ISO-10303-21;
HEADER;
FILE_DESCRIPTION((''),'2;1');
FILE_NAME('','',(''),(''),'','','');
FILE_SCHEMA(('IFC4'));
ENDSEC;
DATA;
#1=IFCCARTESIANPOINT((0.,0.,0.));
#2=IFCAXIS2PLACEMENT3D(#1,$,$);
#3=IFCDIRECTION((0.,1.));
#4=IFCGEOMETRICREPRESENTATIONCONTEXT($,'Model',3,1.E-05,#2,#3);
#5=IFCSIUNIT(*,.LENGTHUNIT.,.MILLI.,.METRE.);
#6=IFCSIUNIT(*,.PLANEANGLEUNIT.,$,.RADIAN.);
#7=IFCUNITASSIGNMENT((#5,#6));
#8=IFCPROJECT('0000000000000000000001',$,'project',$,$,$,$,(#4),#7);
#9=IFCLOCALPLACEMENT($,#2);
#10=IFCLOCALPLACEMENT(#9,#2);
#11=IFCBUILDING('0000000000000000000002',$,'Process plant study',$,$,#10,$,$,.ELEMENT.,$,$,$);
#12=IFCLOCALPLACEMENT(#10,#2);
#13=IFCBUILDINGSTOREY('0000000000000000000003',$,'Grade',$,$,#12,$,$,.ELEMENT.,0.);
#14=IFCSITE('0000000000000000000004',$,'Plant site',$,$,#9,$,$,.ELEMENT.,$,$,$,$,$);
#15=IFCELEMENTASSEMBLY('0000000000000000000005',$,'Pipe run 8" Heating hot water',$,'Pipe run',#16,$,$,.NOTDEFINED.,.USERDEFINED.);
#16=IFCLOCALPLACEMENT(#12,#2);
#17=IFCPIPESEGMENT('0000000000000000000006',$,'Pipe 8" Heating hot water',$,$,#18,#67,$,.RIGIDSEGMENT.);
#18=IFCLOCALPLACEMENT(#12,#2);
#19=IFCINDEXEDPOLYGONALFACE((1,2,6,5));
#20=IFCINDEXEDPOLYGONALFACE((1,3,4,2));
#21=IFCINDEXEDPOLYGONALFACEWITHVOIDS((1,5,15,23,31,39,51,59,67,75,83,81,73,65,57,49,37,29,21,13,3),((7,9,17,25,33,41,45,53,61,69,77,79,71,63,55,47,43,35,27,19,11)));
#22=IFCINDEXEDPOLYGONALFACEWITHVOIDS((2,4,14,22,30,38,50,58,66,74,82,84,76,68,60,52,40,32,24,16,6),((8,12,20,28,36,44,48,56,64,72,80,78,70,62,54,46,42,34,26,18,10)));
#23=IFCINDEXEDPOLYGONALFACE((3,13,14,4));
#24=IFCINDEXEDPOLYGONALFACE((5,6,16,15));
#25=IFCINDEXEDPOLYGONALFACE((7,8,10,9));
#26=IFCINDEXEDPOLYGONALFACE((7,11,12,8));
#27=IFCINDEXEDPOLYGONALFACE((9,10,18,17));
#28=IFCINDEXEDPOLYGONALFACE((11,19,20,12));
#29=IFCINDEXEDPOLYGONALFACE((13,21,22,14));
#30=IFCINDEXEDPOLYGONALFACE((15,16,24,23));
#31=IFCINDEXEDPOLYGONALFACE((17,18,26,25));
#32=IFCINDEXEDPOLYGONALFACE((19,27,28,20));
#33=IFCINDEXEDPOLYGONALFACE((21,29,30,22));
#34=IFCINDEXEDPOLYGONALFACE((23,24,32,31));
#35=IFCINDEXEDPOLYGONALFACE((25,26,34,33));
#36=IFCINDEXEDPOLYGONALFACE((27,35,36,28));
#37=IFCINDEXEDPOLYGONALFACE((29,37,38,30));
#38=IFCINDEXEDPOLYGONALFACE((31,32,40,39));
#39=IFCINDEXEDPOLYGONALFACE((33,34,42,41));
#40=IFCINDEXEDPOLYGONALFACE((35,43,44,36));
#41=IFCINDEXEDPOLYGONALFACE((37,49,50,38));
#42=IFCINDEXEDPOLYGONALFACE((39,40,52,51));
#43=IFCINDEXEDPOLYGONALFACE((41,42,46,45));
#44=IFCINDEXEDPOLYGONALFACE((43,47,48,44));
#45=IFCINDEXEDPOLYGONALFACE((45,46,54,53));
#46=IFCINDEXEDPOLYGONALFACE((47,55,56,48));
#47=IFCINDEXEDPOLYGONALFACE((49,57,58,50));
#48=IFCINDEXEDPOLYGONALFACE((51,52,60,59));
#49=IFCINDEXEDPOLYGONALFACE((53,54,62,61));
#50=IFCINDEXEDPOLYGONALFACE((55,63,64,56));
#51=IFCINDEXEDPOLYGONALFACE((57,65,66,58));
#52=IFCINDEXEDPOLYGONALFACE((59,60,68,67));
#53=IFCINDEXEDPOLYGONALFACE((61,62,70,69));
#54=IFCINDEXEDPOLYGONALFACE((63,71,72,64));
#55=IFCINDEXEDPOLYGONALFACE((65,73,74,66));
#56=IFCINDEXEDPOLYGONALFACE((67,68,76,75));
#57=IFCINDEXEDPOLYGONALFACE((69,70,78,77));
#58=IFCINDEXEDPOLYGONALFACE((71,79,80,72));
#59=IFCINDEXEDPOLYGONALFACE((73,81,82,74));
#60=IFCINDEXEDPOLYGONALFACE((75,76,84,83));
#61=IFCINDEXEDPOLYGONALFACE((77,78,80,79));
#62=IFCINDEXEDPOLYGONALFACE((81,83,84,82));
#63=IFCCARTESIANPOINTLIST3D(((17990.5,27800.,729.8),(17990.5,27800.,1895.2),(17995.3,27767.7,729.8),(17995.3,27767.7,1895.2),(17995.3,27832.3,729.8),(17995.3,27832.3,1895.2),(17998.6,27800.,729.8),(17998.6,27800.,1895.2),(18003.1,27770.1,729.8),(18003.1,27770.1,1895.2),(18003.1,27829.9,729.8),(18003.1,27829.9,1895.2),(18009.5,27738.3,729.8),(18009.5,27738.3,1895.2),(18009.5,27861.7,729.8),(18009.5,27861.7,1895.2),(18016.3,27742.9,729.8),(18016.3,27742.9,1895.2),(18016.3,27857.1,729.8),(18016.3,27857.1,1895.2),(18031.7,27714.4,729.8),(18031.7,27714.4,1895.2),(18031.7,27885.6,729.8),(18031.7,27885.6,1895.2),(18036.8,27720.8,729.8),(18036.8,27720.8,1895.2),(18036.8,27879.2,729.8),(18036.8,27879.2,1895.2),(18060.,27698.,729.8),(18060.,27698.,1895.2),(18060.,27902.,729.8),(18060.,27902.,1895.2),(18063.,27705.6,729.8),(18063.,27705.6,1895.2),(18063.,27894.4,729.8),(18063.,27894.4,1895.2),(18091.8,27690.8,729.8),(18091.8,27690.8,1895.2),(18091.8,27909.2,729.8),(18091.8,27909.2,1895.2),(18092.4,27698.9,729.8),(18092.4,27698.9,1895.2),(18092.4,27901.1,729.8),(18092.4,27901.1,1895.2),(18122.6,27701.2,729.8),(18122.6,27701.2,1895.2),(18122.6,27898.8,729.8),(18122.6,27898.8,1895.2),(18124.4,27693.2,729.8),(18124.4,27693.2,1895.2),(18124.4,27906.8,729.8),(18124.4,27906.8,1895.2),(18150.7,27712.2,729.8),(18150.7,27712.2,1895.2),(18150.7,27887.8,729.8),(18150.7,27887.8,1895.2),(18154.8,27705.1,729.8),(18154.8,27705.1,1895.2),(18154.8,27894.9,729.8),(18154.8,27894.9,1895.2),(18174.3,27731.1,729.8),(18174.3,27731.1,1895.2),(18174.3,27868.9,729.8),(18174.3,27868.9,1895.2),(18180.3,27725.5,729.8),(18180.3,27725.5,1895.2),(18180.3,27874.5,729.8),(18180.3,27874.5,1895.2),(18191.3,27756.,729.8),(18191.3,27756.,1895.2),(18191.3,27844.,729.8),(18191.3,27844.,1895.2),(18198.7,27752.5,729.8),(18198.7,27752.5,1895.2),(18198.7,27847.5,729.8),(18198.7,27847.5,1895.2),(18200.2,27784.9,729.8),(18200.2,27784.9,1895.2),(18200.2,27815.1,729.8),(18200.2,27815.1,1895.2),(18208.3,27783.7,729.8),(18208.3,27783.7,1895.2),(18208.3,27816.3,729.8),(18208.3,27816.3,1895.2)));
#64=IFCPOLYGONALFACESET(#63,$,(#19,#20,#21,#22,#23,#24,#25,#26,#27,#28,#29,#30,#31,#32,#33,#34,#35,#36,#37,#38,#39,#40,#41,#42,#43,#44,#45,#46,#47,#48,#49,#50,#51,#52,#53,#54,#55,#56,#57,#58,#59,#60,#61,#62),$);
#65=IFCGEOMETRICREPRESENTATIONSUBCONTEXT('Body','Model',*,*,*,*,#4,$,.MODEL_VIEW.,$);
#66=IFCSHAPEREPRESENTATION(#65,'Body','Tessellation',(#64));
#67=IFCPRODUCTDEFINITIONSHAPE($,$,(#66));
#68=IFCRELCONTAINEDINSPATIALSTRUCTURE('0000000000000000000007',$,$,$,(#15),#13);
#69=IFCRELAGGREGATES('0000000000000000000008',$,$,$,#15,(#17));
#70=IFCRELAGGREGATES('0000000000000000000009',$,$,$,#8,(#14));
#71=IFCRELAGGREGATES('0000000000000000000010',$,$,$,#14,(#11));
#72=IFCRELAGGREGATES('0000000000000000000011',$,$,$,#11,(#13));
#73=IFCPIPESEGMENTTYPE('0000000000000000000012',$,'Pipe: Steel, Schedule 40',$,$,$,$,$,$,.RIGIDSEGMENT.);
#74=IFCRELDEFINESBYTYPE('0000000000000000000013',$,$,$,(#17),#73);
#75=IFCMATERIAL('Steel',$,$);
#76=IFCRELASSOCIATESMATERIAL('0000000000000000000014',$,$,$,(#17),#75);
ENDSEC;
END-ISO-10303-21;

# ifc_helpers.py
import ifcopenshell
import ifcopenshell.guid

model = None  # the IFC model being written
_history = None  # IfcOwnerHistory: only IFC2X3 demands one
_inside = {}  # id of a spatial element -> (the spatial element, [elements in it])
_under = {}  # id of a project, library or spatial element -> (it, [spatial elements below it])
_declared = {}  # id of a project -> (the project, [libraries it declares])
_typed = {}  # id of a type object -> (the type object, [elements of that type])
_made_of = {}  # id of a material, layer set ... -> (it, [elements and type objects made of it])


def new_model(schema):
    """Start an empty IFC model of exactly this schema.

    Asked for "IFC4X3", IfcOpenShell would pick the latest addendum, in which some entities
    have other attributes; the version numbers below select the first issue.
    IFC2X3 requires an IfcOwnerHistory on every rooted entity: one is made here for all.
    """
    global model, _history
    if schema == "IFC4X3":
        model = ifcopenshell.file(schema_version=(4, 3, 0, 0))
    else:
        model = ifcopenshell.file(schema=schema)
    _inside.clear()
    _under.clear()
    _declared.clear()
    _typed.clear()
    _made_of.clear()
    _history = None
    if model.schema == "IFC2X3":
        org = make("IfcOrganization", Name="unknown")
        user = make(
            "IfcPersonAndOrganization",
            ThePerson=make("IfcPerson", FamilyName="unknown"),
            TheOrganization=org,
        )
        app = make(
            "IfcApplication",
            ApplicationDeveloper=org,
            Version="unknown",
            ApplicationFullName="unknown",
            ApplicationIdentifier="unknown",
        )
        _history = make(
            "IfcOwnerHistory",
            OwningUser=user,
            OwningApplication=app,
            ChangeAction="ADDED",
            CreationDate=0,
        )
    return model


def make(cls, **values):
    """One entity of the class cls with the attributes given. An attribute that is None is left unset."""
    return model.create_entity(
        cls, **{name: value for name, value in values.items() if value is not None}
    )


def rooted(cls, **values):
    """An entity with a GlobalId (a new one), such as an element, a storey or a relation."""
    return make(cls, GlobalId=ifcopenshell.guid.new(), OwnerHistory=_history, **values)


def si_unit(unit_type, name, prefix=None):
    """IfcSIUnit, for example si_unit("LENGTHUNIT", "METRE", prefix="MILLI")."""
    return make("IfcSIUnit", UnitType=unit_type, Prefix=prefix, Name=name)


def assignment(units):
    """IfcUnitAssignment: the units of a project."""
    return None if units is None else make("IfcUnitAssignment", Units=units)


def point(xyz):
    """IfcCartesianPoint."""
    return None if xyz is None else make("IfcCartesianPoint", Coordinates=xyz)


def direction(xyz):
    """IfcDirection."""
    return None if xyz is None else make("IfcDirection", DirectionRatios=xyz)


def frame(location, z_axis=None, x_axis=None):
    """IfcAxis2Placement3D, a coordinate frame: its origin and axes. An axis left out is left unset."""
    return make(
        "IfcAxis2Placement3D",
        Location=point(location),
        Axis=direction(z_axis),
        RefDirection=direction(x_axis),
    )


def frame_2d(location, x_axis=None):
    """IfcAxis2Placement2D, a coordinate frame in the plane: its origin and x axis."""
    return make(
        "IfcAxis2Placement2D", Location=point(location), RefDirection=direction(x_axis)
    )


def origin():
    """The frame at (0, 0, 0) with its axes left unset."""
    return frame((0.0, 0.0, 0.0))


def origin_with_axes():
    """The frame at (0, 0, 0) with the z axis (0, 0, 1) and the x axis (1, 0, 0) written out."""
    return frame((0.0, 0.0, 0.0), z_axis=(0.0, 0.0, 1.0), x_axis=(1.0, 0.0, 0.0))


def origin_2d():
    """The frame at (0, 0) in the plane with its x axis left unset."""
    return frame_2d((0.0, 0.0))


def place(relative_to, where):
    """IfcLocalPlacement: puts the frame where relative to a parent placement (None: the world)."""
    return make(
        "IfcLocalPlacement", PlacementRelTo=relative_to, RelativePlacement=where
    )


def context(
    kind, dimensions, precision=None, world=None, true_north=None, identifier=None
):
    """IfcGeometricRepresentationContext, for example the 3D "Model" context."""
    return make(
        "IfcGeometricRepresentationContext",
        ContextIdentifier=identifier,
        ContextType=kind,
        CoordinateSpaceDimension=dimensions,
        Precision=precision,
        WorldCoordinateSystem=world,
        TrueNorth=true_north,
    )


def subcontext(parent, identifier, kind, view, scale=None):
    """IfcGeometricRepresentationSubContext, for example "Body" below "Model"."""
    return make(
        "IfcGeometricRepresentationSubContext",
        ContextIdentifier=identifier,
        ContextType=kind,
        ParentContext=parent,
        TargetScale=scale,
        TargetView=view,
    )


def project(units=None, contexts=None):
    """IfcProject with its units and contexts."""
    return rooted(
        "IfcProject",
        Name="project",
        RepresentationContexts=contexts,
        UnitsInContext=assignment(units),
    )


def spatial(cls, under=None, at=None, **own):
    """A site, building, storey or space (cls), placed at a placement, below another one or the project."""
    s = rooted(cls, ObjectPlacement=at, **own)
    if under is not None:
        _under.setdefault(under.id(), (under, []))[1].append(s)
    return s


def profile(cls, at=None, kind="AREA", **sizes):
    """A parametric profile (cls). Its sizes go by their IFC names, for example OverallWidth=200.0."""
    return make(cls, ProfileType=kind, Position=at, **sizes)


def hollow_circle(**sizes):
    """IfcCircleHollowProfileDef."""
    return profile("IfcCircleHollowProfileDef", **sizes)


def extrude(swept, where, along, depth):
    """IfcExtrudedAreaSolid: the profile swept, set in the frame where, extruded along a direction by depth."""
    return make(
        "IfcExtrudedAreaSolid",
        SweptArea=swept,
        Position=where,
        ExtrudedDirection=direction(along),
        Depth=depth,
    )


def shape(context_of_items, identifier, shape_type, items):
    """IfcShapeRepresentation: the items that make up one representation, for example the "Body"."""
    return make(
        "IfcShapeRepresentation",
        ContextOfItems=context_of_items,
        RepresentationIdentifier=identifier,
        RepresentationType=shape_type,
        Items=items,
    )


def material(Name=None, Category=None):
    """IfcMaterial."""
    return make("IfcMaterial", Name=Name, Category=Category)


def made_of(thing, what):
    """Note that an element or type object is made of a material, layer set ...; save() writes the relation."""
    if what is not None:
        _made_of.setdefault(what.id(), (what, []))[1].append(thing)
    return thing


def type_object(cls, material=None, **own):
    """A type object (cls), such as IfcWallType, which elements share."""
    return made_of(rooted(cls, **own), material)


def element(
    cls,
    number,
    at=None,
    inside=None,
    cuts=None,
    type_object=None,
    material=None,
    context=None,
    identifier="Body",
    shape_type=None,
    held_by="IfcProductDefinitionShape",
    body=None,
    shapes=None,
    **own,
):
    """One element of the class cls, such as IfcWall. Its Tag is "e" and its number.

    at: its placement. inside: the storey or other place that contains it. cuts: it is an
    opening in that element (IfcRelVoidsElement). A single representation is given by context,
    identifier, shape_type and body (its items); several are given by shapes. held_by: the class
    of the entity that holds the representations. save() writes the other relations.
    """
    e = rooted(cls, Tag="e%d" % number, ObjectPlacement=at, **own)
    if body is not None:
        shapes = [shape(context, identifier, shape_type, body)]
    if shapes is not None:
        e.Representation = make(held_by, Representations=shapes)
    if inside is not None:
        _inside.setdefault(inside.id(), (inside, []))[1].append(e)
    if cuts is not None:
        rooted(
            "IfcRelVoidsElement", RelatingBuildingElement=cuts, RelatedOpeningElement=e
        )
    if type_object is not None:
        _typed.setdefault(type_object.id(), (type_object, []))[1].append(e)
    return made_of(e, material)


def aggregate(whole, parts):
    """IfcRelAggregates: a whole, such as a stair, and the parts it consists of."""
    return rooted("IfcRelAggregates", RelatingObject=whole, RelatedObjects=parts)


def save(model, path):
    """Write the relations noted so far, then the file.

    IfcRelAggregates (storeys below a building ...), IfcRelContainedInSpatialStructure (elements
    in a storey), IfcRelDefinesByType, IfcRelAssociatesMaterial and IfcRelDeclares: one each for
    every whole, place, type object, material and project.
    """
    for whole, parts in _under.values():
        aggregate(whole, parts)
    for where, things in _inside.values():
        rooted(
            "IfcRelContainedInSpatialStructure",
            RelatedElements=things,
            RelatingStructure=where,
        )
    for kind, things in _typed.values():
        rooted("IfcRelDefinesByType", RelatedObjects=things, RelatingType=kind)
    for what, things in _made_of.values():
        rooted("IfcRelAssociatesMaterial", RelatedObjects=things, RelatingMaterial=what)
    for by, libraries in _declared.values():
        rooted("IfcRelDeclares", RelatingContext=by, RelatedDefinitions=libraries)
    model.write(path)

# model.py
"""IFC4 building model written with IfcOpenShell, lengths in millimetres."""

from ifc_helpers import new_model, si_unit, direction, frame, origin, origin_with_axes, origin_2d, place, context, subcontext, project, spatial, hollow_circle, extrude, material, type_object, element, aggregate, save


model = new_model("IFC4")

# Units and contexts
model_context = context("Model", 3, precision=1e-05, world=origin(), true_north=direction((0.0, 1.0)))
body_context = subcontext(model_context, "Body", "Model", "MODEL_VIEW")
ifc_project = project(units=[si_unit("LENGTHUNIT", "METRE", prefix="MILLI"), si_unit("PLANEANGLEUNIT", "RADIAN")], contexts=[model_context])

# Site, building, storey
site_placement = place(None, origin())
site = spatial("IfcSite", under=ifc_project, at=site_placement, Name="Plant site", CompositionType="ELEMENT")
building_placement = place(site_placement, origin())
building = spatial("IfcBuilding", under=site, at=building_placement, Name="Process plant study", CompositionType="ELEMENT")
storey_placement = place(building_placement, origin())
storey = spatial("IfcBuildingStorey", under=building, at=storey_placement, Name="Grade", CompositionType="ELEMENT", Elevation=0.0)

# Element assembly, pipe segment
ifc_material = material(Name="Steel")
pipe_segment_type = type_object("IfcPipeSegmentType", Name="Pipe: Steel, Schedule 40", PredefinedType="RIGIDSEGMENT")
assembly_1_placement = place(storey_placement, origin_with_axes())
assembly_1 = element("IfcElementAssembly", 1, at=assembly_1_placement, inside=storey, Name="Pipe run 8\" Heating hot water", ObjectType="Pipe run", AssemblyPlace="NOTDEFINED", PredefinedType="USERDEFINED")
pipe_segment_1_placement = place(storey_placement, origin_with_axes())
pipe_segment_1 = element("IfcPipeSegment", 2, at=pipe_segment_1_placement, type_object=pipe_segment_type, material=ifc_material, Name="Pipe 8\" Heating hot water", PredefinedType="RIGIDSEGMENT", context=body_context, shape_type="SweptSolid", body=[
    extrude(hollow_circle(Radius=109.5, WallThickness=8.2, at=origin_2d()), frame((18100.0, 27800.0, 1895.2), z_axis=(0.0, 0.0, -1.0), x_axis=(-1.0, 0.0, 0.0)), (0.0, 0.0, 1.0), 1165.4),
])

aggregate(assembly_1, [pipe_segment_1])

save(model, "model.ifc")
